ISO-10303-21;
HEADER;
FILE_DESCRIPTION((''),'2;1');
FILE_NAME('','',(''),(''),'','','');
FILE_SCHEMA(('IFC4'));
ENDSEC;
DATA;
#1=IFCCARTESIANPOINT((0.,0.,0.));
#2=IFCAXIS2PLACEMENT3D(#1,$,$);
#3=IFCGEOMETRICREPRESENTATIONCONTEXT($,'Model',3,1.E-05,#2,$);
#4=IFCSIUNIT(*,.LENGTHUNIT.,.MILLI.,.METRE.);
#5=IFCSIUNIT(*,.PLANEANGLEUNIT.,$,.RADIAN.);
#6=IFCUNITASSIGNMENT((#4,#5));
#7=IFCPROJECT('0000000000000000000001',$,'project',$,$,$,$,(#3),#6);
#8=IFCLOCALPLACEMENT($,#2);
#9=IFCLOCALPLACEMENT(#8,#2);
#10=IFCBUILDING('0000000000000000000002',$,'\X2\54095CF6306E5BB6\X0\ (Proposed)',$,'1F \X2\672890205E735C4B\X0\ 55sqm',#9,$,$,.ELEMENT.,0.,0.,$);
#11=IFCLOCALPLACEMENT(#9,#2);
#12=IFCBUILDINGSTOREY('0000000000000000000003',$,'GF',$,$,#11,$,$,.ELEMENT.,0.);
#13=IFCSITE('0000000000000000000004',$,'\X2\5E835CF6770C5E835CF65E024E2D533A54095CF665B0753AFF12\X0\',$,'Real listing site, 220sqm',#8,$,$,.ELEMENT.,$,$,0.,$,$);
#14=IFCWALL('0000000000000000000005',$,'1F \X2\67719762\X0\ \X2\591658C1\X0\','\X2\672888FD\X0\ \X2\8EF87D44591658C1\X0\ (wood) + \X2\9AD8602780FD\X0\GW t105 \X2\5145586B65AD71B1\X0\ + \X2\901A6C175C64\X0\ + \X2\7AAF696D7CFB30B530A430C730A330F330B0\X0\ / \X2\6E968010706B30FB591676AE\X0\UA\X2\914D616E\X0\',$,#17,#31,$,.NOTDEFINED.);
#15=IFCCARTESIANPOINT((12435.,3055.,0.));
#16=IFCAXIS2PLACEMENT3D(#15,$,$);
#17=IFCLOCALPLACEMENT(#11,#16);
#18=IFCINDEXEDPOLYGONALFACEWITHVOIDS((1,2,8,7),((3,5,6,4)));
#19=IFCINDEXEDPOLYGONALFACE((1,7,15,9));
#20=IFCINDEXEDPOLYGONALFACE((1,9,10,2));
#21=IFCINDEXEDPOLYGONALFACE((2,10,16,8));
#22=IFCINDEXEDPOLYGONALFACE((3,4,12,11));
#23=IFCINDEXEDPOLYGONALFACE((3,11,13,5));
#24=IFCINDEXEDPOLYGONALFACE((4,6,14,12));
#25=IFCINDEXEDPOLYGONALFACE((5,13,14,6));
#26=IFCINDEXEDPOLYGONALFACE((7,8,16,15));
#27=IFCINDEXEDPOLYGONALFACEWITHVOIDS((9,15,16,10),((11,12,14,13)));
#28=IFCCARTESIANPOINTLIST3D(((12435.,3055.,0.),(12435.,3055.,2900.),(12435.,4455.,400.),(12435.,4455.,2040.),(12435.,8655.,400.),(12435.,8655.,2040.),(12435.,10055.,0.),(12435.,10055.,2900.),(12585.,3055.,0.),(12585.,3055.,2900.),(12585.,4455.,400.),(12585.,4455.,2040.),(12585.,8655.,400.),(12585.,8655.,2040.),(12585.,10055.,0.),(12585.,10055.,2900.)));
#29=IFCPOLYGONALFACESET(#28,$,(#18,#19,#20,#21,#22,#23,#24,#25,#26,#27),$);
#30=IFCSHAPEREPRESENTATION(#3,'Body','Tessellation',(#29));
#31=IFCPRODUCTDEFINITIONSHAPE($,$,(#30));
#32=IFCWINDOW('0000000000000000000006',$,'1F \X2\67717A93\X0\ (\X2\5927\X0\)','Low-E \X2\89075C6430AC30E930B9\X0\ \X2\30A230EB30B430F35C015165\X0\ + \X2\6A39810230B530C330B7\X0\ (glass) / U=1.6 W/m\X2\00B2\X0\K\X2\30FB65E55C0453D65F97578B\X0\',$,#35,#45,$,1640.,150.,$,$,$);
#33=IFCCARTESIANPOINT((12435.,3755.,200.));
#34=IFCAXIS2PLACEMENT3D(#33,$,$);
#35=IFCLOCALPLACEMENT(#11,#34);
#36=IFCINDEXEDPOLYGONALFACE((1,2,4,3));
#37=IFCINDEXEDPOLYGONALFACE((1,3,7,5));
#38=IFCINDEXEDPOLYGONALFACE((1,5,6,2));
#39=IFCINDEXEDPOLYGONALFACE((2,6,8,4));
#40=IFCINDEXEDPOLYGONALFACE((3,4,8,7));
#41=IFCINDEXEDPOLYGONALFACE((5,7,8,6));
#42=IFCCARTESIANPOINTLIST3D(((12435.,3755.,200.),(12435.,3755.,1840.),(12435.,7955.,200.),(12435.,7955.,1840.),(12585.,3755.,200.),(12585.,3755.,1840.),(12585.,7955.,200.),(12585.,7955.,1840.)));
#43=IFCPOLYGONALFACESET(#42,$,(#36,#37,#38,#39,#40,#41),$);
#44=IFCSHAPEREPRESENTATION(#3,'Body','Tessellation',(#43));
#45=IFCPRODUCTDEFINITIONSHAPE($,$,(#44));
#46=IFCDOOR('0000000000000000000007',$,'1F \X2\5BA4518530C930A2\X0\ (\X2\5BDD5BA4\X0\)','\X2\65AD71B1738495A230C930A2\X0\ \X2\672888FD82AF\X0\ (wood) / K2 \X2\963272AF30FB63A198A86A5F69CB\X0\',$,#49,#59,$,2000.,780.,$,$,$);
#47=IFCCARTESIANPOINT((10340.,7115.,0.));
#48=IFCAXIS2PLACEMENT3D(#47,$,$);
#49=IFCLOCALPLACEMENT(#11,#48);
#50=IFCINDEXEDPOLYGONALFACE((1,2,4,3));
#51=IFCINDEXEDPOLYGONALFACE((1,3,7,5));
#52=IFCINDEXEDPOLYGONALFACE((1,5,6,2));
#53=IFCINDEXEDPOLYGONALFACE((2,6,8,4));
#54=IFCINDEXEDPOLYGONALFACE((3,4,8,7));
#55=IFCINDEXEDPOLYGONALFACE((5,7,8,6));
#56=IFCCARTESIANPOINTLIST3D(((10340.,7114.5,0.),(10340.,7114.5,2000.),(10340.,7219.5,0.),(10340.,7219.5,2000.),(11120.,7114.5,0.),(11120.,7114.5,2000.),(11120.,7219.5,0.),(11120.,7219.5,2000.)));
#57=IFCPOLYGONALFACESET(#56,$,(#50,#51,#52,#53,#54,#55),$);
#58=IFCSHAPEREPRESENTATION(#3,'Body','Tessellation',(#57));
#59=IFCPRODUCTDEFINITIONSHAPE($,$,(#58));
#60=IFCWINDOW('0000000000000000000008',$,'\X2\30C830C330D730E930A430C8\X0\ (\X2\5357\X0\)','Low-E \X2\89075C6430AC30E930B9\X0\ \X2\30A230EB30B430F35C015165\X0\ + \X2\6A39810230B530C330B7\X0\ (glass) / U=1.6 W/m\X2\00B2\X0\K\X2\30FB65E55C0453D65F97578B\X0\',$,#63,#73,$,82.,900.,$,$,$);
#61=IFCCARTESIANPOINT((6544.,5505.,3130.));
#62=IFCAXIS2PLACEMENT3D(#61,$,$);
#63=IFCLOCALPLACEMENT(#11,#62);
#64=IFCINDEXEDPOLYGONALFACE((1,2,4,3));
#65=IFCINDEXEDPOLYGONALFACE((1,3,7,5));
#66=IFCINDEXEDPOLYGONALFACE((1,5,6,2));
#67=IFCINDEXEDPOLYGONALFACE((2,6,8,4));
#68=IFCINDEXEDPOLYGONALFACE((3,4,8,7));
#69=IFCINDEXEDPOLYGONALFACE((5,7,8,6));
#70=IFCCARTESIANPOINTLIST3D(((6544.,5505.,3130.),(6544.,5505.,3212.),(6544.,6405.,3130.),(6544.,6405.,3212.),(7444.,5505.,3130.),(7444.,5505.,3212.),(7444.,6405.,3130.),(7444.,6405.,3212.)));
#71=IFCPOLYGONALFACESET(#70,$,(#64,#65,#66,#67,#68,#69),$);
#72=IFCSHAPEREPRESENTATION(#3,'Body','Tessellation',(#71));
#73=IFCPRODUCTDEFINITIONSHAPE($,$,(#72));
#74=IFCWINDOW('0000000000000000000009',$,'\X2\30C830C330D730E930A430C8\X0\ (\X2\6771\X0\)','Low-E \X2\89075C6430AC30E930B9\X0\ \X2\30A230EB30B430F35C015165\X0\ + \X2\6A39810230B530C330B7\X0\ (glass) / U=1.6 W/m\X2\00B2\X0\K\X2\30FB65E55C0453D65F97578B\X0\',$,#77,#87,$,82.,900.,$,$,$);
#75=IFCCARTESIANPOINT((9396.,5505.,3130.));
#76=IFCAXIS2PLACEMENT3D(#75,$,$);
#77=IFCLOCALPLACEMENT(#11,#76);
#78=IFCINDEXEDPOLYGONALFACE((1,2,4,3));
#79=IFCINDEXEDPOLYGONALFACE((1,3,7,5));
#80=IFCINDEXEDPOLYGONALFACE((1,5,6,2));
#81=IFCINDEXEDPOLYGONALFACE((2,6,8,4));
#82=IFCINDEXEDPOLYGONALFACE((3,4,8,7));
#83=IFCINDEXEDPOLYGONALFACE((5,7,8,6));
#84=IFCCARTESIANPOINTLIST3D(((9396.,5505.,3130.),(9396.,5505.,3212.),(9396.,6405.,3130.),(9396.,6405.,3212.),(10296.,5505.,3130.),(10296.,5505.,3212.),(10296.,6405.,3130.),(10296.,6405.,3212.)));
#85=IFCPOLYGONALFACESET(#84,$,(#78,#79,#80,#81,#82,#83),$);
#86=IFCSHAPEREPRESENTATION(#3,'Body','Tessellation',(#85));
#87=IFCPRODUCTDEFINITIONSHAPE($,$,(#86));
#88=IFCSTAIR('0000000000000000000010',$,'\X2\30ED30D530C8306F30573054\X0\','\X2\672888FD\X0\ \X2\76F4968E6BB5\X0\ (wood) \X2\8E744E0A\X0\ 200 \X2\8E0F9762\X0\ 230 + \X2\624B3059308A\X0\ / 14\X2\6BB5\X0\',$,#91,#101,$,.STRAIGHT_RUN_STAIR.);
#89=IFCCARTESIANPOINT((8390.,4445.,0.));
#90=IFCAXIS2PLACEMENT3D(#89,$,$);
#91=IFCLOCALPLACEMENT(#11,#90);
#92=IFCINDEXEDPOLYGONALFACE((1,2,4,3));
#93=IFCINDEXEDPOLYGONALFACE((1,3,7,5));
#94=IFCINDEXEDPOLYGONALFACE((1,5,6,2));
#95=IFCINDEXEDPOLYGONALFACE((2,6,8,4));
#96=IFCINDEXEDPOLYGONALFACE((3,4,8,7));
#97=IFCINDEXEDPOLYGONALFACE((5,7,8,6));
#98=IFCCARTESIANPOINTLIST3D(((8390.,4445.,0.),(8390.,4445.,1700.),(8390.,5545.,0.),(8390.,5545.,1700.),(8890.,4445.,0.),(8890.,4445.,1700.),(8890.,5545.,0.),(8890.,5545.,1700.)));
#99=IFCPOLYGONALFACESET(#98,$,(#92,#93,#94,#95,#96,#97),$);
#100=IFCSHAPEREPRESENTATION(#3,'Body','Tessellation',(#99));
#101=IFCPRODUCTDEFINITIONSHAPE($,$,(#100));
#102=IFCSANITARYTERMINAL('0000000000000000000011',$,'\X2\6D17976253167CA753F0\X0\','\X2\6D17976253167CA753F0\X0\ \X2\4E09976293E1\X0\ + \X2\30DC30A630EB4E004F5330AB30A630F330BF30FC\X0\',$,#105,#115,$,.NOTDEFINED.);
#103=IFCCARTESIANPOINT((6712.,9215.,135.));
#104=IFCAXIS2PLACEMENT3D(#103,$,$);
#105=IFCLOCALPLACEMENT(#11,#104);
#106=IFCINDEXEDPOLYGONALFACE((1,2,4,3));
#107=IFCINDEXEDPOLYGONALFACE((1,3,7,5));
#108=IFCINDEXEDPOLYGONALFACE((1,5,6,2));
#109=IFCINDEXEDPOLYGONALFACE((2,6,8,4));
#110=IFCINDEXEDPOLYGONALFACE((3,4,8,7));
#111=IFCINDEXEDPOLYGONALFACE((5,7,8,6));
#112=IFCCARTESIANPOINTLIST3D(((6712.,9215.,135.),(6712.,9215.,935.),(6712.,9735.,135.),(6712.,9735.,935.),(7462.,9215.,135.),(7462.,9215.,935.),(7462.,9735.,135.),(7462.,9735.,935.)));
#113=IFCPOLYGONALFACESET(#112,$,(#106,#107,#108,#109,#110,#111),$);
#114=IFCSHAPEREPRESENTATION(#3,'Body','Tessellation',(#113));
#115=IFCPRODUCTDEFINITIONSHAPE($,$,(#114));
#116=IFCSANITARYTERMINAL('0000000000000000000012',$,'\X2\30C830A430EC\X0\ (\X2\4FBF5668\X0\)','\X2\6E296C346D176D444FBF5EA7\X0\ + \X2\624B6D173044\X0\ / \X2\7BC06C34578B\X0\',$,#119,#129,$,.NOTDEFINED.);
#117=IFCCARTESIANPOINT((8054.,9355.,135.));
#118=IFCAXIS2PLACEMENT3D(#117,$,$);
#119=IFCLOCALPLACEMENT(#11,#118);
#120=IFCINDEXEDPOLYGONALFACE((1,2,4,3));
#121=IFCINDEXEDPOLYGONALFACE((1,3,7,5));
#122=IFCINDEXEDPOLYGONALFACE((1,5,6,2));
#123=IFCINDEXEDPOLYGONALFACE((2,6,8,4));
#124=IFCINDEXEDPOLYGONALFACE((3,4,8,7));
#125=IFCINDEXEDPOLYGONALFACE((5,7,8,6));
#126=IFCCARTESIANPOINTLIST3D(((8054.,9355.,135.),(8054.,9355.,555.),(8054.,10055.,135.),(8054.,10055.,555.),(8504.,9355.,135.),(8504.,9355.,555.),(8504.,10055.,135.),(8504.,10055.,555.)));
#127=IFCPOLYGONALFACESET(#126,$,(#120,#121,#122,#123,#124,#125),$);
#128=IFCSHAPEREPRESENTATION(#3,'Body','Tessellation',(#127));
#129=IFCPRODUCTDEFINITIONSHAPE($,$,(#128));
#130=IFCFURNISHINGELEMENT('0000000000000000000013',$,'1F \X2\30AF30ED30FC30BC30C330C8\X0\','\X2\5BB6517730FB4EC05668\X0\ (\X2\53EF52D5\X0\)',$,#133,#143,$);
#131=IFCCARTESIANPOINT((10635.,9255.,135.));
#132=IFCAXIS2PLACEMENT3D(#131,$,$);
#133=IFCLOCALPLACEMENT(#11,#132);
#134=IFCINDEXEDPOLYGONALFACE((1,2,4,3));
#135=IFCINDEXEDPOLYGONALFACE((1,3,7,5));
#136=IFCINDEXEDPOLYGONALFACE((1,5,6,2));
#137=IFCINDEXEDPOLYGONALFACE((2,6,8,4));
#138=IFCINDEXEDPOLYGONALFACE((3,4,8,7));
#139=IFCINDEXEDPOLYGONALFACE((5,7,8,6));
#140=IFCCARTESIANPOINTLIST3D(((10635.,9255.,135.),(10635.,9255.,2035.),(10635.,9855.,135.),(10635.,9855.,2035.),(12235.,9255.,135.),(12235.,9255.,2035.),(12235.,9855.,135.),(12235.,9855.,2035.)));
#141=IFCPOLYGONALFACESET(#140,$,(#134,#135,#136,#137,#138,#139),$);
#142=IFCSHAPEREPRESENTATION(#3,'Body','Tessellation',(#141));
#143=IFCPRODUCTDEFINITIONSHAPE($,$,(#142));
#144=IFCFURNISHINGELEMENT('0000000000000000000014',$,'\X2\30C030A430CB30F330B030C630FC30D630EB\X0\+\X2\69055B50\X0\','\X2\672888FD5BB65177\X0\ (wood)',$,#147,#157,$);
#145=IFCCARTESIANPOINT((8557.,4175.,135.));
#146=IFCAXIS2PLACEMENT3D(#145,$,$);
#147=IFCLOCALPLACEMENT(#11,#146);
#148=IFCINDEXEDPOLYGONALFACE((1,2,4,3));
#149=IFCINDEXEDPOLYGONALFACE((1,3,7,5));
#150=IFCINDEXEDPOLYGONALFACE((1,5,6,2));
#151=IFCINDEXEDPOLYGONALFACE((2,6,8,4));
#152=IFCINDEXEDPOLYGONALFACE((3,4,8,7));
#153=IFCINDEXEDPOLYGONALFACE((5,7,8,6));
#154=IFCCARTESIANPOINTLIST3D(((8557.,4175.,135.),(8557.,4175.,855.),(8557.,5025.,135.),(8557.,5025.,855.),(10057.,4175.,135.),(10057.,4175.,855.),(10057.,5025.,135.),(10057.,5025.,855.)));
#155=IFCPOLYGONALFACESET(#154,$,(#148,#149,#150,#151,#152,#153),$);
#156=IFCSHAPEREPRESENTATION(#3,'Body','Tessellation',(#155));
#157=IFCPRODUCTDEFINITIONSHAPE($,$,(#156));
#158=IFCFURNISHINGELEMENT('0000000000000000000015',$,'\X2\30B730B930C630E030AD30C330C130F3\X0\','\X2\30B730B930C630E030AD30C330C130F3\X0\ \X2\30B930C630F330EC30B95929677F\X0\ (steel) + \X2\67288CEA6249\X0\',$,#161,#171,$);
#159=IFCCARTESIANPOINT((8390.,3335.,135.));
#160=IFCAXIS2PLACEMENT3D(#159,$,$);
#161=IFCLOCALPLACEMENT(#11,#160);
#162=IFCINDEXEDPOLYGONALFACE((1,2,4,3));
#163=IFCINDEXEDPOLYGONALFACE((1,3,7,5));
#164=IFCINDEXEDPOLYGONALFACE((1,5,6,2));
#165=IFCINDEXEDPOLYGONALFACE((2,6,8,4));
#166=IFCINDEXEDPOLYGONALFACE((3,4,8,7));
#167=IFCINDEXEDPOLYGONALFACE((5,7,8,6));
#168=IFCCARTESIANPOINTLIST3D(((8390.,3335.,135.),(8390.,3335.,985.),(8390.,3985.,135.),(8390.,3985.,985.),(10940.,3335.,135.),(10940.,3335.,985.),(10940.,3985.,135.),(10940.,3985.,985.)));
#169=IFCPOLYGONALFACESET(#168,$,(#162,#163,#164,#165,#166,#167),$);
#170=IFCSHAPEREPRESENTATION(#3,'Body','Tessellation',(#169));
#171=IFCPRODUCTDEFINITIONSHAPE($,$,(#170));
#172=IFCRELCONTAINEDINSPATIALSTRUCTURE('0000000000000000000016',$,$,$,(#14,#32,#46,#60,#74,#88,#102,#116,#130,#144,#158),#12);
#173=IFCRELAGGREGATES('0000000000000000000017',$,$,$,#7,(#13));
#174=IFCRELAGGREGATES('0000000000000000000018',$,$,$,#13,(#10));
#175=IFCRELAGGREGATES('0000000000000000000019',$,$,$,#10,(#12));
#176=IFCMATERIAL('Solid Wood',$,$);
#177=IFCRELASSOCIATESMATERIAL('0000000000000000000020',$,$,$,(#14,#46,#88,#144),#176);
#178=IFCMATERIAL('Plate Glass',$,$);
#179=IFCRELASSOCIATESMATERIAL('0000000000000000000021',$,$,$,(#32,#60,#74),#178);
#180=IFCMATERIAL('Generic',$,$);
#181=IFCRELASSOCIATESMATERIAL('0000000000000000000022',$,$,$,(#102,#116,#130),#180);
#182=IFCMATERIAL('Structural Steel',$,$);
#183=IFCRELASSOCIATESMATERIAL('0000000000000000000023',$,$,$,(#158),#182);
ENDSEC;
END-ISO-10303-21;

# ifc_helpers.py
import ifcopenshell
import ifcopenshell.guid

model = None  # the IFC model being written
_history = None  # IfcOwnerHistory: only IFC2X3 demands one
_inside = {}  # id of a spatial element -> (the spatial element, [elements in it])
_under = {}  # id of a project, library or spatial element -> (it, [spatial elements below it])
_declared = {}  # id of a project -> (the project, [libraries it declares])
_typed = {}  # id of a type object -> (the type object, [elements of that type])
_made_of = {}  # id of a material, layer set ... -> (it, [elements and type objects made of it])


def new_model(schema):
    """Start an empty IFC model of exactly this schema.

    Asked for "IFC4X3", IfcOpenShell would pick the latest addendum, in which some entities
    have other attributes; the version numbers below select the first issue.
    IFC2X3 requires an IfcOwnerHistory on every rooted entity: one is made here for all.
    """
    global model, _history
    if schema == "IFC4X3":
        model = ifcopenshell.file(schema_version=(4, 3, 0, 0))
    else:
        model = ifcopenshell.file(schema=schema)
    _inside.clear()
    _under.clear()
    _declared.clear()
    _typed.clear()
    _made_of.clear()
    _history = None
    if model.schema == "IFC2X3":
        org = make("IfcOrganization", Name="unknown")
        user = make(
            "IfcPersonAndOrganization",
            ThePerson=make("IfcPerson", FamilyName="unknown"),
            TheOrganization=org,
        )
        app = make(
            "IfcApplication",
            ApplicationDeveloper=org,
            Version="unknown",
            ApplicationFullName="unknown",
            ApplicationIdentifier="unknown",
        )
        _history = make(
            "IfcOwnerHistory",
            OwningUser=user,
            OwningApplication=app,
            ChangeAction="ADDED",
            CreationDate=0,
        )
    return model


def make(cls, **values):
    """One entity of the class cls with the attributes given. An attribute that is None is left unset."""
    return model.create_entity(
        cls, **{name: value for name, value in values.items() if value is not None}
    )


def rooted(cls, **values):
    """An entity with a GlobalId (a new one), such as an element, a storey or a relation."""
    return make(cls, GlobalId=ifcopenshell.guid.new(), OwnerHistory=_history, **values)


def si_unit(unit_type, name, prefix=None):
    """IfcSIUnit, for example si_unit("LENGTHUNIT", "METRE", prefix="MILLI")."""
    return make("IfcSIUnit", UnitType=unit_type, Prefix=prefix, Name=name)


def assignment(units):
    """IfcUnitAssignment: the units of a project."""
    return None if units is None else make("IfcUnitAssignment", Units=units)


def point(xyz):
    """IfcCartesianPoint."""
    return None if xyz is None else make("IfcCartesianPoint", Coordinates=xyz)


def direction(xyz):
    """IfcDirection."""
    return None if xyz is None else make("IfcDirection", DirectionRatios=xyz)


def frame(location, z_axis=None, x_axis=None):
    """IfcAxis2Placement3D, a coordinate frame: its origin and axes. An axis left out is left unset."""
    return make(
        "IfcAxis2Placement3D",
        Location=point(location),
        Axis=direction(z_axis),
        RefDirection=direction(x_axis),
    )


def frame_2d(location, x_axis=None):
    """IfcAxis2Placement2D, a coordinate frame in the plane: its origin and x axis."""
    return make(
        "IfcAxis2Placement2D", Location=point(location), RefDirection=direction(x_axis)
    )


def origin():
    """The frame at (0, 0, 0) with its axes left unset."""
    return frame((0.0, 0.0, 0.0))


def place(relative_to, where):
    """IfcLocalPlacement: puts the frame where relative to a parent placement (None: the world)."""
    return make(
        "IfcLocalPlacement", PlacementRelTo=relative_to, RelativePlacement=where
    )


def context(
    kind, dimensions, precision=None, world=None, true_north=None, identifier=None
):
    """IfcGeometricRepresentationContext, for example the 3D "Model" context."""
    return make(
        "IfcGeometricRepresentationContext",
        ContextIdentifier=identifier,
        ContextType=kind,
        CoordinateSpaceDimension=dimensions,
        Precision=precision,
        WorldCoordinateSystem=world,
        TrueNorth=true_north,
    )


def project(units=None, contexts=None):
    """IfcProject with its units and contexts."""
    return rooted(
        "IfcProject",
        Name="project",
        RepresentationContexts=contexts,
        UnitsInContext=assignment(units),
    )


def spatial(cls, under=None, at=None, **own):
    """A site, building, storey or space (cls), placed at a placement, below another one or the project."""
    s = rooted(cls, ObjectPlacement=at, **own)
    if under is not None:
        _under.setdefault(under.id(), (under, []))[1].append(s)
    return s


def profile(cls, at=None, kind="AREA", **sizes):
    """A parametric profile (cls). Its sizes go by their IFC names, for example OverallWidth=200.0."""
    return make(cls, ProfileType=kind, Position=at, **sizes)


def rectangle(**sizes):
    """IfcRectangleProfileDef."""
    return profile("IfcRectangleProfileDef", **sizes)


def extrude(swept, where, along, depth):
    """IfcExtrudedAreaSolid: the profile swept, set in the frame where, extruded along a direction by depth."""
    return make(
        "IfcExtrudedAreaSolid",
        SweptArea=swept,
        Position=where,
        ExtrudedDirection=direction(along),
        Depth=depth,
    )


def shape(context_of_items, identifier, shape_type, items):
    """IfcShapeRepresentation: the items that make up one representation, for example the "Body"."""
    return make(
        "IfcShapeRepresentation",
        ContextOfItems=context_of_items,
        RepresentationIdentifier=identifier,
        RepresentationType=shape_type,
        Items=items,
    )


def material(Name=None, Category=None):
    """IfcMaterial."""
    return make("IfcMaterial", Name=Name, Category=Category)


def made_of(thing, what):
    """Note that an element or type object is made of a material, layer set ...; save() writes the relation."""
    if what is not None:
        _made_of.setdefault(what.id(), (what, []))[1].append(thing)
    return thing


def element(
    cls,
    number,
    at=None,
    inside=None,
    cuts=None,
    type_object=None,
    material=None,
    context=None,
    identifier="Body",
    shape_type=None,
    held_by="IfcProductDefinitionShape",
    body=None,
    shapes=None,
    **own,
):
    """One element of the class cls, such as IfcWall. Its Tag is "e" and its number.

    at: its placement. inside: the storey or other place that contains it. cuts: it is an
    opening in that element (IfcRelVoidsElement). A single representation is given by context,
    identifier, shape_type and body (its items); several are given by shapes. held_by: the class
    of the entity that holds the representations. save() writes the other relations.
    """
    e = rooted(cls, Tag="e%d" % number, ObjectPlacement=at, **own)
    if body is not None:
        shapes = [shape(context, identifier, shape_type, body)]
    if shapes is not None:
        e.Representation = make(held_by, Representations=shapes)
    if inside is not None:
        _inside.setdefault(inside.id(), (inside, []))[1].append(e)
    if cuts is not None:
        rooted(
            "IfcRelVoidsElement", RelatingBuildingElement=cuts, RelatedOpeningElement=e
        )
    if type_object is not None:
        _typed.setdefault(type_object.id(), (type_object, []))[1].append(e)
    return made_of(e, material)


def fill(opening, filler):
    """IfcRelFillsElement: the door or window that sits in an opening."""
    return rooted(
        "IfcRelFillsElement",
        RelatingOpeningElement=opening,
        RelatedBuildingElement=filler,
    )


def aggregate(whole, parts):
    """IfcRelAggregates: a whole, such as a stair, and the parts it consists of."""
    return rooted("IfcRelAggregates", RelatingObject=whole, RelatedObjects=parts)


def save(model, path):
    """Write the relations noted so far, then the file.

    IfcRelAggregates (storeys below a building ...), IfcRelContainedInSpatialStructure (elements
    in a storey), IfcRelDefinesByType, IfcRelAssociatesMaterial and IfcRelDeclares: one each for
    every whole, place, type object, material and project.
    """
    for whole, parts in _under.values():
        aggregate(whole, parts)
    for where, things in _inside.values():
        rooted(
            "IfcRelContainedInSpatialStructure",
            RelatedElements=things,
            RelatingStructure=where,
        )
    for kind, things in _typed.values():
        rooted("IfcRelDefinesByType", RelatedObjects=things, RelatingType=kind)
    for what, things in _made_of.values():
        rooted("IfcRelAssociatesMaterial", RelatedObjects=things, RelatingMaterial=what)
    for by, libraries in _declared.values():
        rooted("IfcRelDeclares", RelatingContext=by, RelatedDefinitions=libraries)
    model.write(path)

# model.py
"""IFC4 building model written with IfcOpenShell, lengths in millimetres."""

from ifc_helpers import new_model, si_unit, frame, frame_2d, origin, place, context, project, spatial, rectangle, extrude, material, element, fill, save


model = new_model("IFC4")

# Units and contexts
model_context = context("Model", 3, precision=1e-05, world=origin())
ifc_project = project(units=[si_unit("LENGTHUNIT", "METRE", prefix="MILLI"), si_unit("PLANEANGLEUNIT", "RADIAN")], contexts=[model_context])

# Site, building, storey
site_placement = place(None, origin())
site = spatial("IfcSite", under=ifc_project, at=site_placement, Name="広島県広島市中区吉島新町２", ObjectType="Real listing site, 220sqm", CompositionType="ELEMENT", RefElevation=0.0)
building_placement = place(site_placement, origin())
building = spatial("IfcBuilding", under=site, at=building_placement, Name="吉島の家 (Proposed)", ObjectType="1F 木造平屋 55sqm", CompositionType="ELEMENT", ElevationOfRefHeight=0.0, ElevationOfTerrain=0.0)
storey_placement = place(building_placement, origin())
storey = spatial("IfcBuildingStorey", under=building, at=storey_placement, Name="GF", CompositionType="ELEMENT", Elevation=0.0)

# Wall, opening, window
ifc_material_1 = material(Name="Solid Wood")
wall_1_placement = place(storey_placement, frame((12435.0, 3055.0, 0.0)))
wall_1 = element("IfcWall", 1, at=wall_1_placement, inside=storey, material=ifc_material_1, Name="1F 東面 外壁", Description="木製 軸組外壁 (wood) + 高性能GW t105 充填断熱 + 通気層 + 窯業系サイディング / 準耐火・外皮UA配慮", PredefinedType="NOTDEFINED", context=model_context, shape_type="SweptSolid", body=[
    extrude(rectangle(XDim=150.0, YDim=7000.0, at=frame_2d((75.0, 3500.0))), frame((12435.0, 3055.0, 0.0)), (0.0, 0.0, 1.0), 2900.0),
])
opening_placement = place(storey_placement, frame((12435.0, 3755.0, 200.0)))
opening = element("IfcOpeningElement", 2, at=opening_placement, cuts=wall_1, PredefinedType="NOTDEFINED", context=model_context, shape_type="SweptSolid", body=[
    extrude(rectangle(XDim=150.0, YDim=4200.0, at=frame_2d((75.0, 2100.0))), frame((12435.0, 3755.0, 200.0)), (0.0, 0.0, 1.0), 1640.0),
])
ifc_material_2 = material(Name="Plate Glass")
window_1_placement = place(storey_placement, frame((12435.0, 3755.0, 200.0)))
window_1 = element("IfcWindow", 3, at=window_1_placement, inside=storey, material=ifc_material_2, Name="1F 東窓 (大)", Description="Low-E 複層ガラス アルゴン封入 + 樹脂サッシ (glass) / U=1.6 W/m²K・日射取得型", OverallHeight=1640.0, OverallWidth=150.0, context=model_context, shape_type="SweptSolid", body=[
    extrude(rectangle(XDim=150.0, YDim=4200.0, at=frame_2d((75.0, 2100.0))), frame((12435.0, 3755.0, 200.0)), (0.0, 0.0, 1.0), 1640.0),
])
fill(opening, window_1)

# Door
door_placement = place(storey_placement, frame((10340.0, 7115.0, 0.0)))
element("IfcDoor", 4, at=door_placement, inside=storey, material=ifc_material_1, Name="1F 室内ドア (寝室)", Description="断熱玄関ドア 木製芯 (wood) / K2 防犯・採風機構", OverallHeight=2000.0, OverallWidth=780.0, context=model_context, shape_type="SweptSolid", body=[
    extrude(rectangle(XDim=780.0, YDim=105.0, at=frame_2d((390.0, 52.0))), frame((10340.0, 7115.0, 0.0)), (0.0, 0.0, 1.0), 2000.0),
])

# Windows
window_2_placement = place(storey_placement, frame((6544.0, 5505.0, 3130.0)))
element("IfcWindow", 5, at=window_2_placement, inside=storey, material=ifc_material_2, Name="トップライト (南)", Description="Low-E 複層ガラス アルゴン封入 + 樹脂サッシ (glass) / U=1.6 W/m²K・日射取得型", OverallHeight=82.0, OverallWidth=900.0, context=model_context, shape_type="SweptSolid", body=[
    extrude(rectangle(XDim=900.0, YDim=900.0, at=frame_2d((450.0, 450.0))), frame((6544.0, 5505.0, 3130.0)), (0.0, 0.0, 1.0), 82.0),
])
window_3_placement = place(storey_placement, frame((9396.0, 5505.0, 3130.0)))
element("IfcWindow", 6, at=window_3_placement, inside=storey, material=ifc_material_2, Name="トップライト (東)", Description="Low-E 複層ガラス アルゴン封入 + 樹脂サッシ (glass) / U=1.6 W/m²K・日射取得型", OverallHeight=82.0, OverallWidth=900.0, context=model_context, shape_type="SweptSolid", body=[
    extrude(rectangle(XDim=900.0, YDim=900.0, at=frame_2d((450.0, 450.0))), frame((9396.0, 5505.0, 3130.0)), (0.0, 0.0, 1.0), 82.0),
])

# Stair
stair_placement = place(storey_placement, frame((8390.0, 4445.0, 0.0)))
element("IfcStair", 7, at=stair_placement, inside=storey, material=ifc_material_1, Name="ロフトはしご", Description="木製 直階段 (wood) 蹴上 200 踏面 230 + 手すり / 14段", PredefinedType="STRAIGHT_RUN_STAIR", context=model_context, shape_type="SweptSolid", body=[
    extrude(rectangle(XDim=500.0, YDim=1100.0, at=frame_2d((250.0, 550.0))), frame((8390.0, 4445.0, 0.0)), (0.0, 0.0, 1.0), 1700.0),
])

# Sanitary terminals
ifc_material_3 = material(Name="Generic")
sanitary_terminal_1_placement = place(storey_placement, frame((6712.0, 9215.0, 135.0)))
element("IfcSanitaryTerminal", 8, at=sanitary_terminal_1_placement, inside=storey, material=ifc_material_3, Name="洗面化粧台", Description="洗面化粧台 三面鏡 + ボウル一体カウンター", PredefinedType="NOTDEFINED", context=model_context, shape_type="SweptSolid", body=[
    extrude(rectangle(XDim=750.0, YDim=520.0, at=frame_2d((375.0, 260.0))), frame((6712.0, 9215.0, 135.0)), (0.0, 0.0, 1.0), 800.0),
])
sanitary_terminal_2_placement = place(storey_placement, frame((8054.0, 9355.0, 135.0)))
element("IfcSanitaryTerminal", 9, at=sanitary_terminal_2_placement, inside=storey, material=ifc_material_3, Name="トイレ (便器)", Description="温水洗浄便座 + 手洗い / 節水型", PredefinedType="NOTDEFINED", context=model_context, shape_type="SweptSolid", body=[
    extrude(rectangle(XDim=450.0, YDim=700.0, at=frame_2d((225.0, 350.0))), frame((8054.0, 9355.0, 135.0)), (0.0, 0.0, 1.0), 420.0),
])

# Furnishing elements
furnishing_1_placement = place(storey_placement, frame((10635.0, 9255.0, 135.0)))
element("IfcFurnishingElement", 10, at=furnishing_1_placement, inside=storey, material=ifc_material_3, Name="1F クローゼット", Description="家具・什器 (可動)", context=model_context, shape_type="SweptSolid", body=[
    extrude(rectangle(XDim=1600.0, YDim=600.0, at=frame_2d((800.0, 300.0))), frame((10635.0, 9255.0, 135.0)), (0.0, 0.0, 1.0), 1900.0),
])
furnishing_2_placement = place(storey_placement, frame((8557.0, 4175.0, 135.0)))
element("IfcFurnishingElement", 11, at=furnishing_2_placement, inside=storey, material=ifc_material_1, Name="ダイニングテーブル+椅子", Description="木製家具 (wood)", context=model_context, shape_type="SweptSolid", body=[
    extrude(rectangle(XDim=1500.0, YDim=850.0, at=frame_2d((750.0, 425.0))), frame((8557.0, 4175.0, 135.0)), (0.0, 0.0, 1.0), 720.0),
])
ifc_material_4 = material(Name="Structural Steel")
furnishing_3_placement = place(storey_placement, frame((8390.0, 3335.0, 135.0)))
element("IfcFurnishingElement", 12, at=furnishing_3_placement, inside=storey, material=ifc_material_4, Name="システムキッチン", Description="システムキッチン ステンレス天板 (steel) + 木質扉", context=model_context, shape_type="SweptSolid", body=[
    extrude(rectangle(XDim=2550.0, YDim=650.0, at=frame_2d((1275.0, 325.0))), frame((8390.0, 3335.0, 135.0)), (0.0, 0.0, 1.0), 850.0),
])

save(model, "model.ifc")
